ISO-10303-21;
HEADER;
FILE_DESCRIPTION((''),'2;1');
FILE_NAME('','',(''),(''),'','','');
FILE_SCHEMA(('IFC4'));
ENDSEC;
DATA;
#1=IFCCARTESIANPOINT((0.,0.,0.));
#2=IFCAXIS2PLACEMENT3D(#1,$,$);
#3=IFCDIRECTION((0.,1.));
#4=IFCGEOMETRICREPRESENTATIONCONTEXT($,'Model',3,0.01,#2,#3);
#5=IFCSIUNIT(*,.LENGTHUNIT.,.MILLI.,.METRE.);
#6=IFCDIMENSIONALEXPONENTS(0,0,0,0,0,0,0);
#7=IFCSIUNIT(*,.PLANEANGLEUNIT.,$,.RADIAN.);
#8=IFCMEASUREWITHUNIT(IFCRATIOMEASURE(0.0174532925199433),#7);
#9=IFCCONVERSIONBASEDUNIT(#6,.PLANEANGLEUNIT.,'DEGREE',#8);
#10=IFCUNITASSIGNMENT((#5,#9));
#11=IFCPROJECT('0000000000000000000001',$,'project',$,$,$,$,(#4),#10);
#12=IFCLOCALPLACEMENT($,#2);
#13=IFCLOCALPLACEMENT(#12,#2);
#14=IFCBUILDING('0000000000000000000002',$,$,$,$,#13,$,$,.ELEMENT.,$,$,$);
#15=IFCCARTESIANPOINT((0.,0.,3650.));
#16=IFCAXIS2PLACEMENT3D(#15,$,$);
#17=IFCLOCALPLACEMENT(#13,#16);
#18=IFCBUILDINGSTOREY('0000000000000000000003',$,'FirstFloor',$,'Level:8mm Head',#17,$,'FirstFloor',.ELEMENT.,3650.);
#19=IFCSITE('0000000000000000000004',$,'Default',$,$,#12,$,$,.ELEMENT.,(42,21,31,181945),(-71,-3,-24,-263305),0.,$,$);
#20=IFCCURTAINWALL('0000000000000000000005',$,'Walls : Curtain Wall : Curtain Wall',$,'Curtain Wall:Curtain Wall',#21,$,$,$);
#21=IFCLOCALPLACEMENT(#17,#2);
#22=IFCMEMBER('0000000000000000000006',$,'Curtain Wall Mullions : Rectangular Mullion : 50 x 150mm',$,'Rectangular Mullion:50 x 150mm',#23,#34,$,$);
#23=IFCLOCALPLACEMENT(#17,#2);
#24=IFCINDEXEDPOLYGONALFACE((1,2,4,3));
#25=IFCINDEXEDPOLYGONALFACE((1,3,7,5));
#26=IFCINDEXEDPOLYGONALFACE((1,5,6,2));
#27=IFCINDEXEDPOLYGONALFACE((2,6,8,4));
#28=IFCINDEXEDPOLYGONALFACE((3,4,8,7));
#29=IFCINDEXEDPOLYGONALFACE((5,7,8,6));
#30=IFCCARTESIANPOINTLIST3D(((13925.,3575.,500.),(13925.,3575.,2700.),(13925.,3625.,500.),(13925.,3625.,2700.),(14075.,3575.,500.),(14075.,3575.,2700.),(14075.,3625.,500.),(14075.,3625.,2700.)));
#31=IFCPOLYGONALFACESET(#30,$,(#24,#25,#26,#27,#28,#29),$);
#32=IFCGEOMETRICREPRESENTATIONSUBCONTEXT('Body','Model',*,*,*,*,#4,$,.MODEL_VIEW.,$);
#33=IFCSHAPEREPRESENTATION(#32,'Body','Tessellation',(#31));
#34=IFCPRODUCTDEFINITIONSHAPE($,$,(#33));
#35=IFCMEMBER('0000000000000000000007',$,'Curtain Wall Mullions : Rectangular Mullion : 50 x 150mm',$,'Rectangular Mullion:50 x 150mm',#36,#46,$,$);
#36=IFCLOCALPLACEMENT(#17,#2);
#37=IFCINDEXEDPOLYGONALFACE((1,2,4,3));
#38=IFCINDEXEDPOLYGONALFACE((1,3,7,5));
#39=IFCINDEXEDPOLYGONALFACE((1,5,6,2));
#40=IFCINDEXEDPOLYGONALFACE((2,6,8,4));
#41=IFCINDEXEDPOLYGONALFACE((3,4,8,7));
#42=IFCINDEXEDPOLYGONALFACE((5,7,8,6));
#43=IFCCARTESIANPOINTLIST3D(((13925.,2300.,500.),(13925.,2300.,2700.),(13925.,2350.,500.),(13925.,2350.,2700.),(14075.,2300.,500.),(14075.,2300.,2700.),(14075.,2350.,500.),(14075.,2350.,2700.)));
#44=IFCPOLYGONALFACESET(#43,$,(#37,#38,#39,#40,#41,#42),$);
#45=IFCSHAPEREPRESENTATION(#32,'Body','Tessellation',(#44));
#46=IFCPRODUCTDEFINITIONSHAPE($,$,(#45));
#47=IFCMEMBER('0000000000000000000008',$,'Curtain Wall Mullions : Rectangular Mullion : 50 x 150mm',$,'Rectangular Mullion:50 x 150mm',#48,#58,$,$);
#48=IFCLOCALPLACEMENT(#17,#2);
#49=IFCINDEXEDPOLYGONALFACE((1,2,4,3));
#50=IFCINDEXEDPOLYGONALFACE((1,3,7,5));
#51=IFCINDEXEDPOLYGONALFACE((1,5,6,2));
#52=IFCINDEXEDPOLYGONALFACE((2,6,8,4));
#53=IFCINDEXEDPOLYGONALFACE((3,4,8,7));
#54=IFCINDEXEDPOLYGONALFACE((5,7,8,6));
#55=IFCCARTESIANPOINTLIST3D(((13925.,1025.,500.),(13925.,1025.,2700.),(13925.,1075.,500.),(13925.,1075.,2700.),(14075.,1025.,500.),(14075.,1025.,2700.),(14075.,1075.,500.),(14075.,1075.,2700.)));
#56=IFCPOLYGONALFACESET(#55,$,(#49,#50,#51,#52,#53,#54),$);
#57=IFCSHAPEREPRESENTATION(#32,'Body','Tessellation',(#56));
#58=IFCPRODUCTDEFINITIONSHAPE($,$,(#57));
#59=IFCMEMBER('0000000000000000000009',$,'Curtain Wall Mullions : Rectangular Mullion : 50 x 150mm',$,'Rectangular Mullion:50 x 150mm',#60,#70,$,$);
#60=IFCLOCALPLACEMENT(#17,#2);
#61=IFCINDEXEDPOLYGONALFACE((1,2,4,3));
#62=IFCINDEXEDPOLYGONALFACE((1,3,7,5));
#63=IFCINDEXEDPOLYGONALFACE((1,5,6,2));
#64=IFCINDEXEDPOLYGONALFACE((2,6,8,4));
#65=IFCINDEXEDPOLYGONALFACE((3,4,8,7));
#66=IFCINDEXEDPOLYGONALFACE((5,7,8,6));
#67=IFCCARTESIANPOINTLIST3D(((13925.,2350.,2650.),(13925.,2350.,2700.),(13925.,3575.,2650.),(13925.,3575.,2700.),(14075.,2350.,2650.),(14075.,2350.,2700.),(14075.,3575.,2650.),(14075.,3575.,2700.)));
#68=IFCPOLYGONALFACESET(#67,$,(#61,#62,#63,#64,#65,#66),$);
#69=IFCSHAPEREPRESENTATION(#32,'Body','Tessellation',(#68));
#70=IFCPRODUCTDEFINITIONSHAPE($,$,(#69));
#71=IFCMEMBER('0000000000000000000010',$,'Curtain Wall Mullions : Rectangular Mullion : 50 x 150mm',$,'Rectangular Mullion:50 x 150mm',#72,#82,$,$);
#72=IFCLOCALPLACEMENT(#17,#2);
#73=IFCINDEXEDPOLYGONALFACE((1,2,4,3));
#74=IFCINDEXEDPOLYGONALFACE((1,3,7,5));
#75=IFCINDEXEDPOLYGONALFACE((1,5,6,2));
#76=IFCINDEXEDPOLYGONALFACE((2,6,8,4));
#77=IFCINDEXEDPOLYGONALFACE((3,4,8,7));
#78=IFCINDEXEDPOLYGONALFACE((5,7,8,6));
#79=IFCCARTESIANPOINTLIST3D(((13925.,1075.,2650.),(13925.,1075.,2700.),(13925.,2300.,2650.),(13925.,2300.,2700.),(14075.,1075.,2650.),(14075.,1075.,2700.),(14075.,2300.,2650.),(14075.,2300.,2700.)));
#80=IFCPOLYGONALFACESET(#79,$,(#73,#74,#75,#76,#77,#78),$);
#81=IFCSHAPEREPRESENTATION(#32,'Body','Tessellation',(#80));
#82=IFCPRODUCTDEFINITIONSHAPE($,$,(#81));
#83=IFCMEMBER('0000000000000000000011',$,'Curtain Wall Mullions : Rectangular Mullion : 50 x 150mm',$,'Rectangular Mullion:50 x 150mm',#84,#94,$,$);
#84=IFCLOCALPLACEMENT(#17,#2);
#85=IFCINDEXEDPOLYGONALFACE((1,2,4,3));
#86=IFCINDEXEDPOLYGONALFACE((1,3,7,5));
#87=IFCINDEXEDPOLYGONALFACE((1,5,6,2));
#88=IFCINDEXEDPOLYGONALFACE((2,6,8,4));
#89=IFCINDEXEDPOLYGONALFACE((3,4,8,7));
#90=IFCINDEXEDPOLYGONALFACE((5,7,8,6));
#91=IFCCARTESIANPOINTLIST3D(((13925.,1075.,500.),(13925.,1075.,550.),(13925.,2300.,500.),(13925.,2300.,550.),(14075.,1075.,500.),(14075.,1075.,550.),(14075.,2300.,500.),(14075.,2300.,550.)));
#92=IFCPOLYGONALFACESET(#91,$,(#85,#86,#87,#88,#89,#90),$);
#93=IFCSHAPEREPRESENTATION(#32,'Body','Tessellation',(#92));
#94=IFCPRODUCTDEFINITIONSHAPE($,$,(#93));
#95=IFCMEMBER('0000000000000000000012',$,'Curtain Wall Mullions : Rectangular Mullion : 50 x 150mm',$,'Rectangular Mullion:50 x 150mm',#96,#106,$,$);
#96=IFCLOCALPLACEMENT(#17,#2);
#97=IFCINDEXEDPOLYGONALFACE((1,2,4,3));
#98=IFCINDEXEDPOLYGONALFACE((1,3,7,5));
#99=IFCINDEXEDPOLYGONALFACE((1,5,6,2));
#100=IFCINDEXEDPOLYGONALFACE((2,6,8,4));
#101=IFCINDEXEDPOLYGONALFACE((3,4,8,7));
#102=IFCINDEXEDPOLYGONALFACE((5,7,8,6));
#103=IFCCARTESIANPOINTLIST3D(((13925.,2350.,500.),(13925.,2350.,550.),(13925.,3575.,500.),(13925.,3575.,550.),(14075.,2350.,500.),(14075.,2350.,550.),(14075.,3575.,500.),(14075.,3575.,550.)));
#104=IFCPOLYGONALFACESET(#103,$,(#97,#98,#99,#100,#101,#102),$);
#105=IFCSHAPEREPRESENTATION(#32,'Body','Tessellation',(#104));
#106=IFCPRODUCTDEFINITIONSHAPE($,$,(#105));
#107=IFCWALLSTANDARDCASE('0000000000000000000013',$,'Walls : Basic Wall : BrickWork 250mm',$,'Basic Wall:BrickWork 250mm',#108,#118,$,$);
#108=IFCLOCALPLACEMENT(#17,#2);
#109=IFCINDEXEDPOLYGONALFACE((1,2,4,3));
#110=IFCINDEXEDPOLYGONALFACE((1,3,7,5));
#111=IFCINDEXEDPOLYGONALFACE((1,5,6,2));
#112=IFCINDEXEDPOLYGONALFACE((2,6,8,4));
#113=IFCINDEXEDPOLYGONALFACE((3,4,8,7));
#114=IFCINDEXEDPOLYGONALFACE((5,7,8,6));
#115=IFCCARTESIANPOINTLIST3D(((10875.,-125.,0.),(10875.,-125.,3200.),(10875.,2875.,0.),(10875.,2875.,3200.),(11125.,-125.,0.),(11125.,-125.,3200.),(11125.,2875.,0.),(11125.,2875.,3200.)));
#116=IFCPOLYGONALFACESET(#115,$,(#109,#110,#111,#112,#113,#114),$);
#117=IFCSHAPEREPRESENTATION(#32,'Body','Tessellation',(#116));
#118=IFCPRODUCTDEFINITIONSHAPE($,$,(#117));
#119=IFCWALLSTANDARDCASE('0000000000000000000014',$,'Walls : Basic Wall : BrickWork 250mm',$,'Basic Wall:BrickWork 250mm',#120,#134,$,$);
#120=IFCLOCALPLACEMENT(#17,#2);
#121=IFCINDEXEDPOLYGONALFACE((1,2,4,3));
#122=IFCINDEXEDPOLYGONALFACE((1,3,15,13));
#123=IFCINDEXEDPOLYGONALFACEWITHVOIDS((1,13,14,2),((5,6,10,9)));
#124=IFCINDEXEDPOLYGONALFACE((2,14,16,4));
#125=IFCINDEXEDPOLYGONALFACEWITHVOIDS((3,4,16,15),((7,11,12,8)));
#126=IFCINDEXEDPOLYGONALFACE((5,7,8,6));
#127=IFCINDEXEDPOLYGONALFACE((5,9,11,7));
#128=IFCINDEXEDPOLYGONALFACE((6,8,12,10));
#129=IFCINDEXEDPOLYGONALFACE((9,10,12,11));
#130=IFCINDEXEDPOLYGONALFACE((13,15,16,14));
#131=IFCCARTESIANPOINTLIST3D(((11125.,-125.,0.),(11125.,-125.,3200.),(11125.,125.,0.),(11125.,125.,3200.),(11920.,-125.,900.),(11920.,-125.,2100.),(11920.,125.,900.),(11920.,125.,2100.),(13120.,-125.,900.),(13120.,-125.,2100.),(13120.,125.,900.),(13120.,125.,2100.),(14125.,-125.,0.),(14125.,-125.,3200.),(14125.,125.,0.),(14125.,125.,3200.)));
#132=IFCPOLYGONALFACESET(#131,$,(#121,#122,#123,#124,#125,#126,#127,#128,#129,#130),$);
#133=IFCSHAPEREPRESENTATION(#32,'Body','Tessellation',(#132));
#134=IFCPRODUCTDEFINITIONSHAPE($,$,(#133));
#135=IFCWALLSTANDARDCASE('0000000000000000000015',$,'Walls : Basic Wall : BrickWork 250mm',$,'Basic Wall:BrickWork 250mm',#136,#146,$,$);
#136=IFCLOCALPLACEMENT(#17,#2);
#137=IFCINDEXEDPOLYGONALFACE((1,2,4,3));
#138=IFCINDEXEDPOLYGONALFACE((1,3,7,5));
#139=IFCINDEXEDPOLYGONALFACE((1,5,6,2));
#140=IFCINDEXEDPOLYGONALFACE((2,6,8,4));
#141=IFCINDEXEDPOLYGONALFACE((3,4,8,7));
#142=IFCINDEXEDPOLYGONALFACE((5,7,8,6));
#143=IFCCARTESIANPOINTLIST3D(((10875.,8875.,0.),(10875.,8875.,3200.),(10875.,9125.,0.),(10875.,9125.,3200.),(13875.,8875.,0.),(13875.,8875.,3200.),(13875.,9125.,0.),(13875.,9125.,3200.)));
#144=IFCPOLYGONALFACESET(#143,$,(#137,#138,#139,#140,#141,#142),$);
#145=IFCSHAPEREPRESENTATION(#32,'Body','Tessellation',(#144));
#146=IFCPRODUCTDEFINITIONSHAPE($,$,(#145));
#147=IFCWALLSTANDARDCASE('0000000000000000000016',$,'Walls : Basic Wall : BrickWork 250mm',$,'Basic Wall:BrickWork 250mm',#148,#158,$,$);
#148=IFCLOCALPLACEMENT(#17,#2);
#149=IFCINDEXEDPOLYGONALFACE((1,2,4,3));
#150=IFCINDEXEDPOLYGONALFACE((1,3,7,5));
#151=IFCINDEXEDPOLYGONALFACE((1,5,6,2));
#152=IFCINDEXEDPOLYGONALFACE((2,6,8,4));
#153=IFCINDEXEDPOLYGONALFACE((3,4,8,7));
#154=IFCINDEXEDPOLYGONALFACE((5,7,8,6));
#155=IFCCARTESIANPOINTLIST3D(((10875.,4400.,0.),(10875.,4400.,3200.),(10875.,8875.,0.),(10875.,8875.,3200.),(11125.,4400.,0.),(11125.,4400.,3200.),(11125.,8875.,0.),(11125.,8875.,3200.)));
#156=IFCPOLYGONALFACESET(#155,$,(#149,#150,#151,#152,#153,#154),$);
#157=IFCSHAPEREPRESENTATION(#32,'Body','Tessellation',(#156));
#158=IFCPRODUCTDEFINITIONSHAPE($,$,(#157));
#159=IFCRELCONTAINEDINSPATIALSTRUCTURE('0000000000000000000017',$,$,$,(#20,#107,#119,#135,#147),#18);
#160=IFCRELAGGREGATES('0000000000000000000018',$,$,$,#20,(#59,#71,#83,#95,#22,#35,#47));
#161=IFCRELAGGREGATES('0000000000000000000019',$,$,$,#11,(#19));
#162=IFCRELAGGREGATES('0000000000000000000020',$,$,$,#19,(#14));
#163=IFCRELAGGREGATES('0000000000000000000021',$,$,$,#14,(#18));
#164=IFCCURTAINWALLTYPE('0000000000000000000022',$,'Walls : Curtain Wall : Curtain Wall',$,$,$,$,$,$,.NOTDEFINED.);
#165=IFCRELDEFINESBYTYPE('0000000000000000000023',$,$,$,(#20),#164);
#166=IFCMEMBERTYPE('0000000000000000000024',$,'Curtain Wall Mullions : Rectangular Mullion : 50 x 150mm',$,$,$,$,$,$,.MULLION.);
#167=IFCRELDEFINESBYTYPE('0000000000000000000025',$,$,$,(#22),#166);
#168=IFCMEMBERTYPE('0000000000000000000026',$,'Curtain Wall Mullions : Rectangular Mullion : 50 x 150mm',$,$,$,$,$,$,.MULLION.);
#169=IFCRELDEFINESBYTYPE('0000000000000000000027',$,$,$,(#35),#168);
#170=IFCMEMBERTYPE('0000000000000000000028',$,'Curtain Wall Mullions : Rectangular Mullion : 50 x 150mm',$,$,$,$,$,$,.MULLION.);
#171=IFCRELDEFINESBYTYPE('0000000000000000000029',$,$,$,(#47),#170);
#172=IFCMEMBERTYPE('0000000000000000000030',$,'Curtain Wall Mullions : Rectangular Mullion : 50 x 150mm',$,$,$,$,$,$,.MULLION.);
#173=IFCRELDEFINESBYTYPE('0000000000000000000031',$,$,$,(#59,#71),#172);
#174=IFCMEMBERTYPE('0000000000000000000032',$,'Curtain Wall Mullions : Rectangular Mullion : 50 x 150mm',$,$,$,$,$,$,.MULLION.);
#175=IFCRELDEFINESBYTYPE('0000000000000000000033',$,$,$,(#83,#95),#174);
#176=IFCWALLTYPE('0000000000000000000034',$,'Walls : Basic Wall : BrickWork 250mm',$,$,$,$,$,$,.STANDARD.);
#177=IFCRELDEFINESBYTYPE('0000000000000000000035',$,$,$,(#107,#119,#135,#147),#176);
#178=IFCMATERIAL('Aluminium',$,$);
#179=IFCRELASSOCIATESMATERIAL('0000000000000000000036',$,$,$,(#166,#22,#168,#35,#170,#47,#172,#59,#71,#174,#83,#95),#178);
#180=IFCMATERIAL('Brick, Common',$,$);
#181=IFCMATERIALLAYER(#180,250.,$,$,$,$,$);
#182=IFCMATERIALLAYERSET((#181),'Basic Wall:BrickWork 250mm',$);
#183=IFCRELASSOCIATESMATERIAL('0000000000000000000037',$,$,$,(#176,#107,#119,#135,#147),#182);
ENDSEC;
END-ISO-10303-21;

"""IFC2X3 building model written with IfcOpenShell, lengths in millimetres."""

from ifc_helpers import new_model, entity, si_unit, converted_unit, direction, frame, frame_2d, origin, origin_2d_with_axis, place, context, subcontext, project, spatial, rectangle, extrude, clip, halfspace, source, transform, mapped, material, layer, layer_set, layer_usage, type_object, type_shapes, element, aggregate, save


model = new_model("IFC2X3")

# Units and contexts
model_context = context("Model", 3, precision=0.01, world=origin(), true_north=direction((0.0, 1.0)))
body_context = subcontext(model_context, "Body", "Model", "MODEL_VIEW")
ifc_project = project(units=[si_unit("LENGTHUNIT", "METRE", prefix="MILLI"), converted_unit("PLANEANGLEUNIT", "DEGREE", entity("IfcRatioMeasure", 0.0174532925199433), si_unit("PLANEANGLEUNIT", "RADIAN"), dimensions=[0, 0, 0, 0, 0, 0, 0])], contexts=[model_context])

# Site, building, storey
site_placement = place(None, origin())
site = spatial("IfcSite", under=ifc_project, at=site_placement, Name="Default", CompositionType="ELEMENT", RefLatitude=(42, 21, 31, 181945), RefLongitude=(-71, -3, -24, -263305), RefElevation=0.0)
building_placement = place(site_placement, origin())
building = spatial("IfcBuilding", under=site, at=building_placement, CompositionType="ELEMENT")
storey_placement = place(building_placement, frame((0.0, 0.0, 3650.0)))
storey = spatial("IfcBuildingStorey", under=building, at=storey_placement, Name="FirstFloor", ObjectType="Level:8mm Head", LongName="FirstFloor", CompositionType="ELEMENT", Elevation=3650.0)

# Curtain wall, members
curtain_wall_type = type_object("IfcCurtainWallType", Name="Walls : Curtain Wall : Curtain Wall", PredefinedType="NOTDEFINED")
curtain_wall_placement = place(storey_placement, frame((0.0, 0.0, -3650.0)))
curtain_wall = element("IfcCurtainWall", 1, at=curtain_wall_placement, inside=storey, type_object=curtain_wall_type, Name="Walls : Curtain Wall : Curtain Wall", ObjectType="Curtain Wall:Curtain Wall")
ifc_material_1 = material(Name="Aluminium")
member_type_1 = type_object("IfcMemberType", Name="Curtain Wall Mullions : Rectangular Mullion : 50 x 150mm", PredefinedType="MULLION", material=ifc_material_1)
shared_shape_1 = source(origin(), body_context, "Body", "SweptSolid", [
    extrude(rectangle(XDim=150.0, YDim=50.0, at=origin_2d_with_axis()), frame((-25.0, 0.0, -2200.0), z_axis=(0.0, 0.0, 1.0), x_axis=(0.0, -1.0, 0.0)), (0.0, 0.0, 1.0), 2200.0),
])
type_shapes(member_type_1, [shared_shape_1])
member_1_placement = place(storey_placement, frame((14000.0, 3625.0, 500.0), z_axis=(0.0, 0.0, -1.0), x_axis=(0.0, 1.0, 0.0)))
member_1 = element("IfcMember", 2, at=member_1_placement, type_object=member_type_1, material=ifc_material_1, Name="Curtain Wall Mullions : Rectangular Mullion : 50 x 150mm", ObjectType="Rectangular Mullion:50 x 150mm", context=body_context, shape_type="MappedRepresentation", body=[
    mapped(shared_shape_1, transform((0.0, 0.0, 0.0), scale=1.0)),
])
member_type_2 = type_object("IfcMemberType", Name="Curtain Wall Mullions : Rectangular Mullion : 50 x 150mm", PredefinedType="MULLION", material=ifc_material_1)
shared_shape_2 = source(origin(), body_context, "Body", "SweptSolid", [
    extrude(rectangle(XDim=150.0, YDim=50.0, at=origin_2d_with_axis()), frame((0.0, 0.0, -2200.0), z_axis=(0.0, 0.0, 1.0), x_axis=(0.0, -1.0, 0.0)), (0.0, 0.0, 1.0), 2200.0),
])
type_shapes(member_type_2, [shared_shape_2])
member_2_placement = place(storey_placement, frame((14000.0, 2325.0, 500.0), z_axis=(0.0, 0.0, -1.0), x_axis=(0.0, 1.0, 0.0)))
member_2 = element("IfcMember", 3, at=member_2_placement, type_object=member_type_2, material=ifc_material_1, Name="Curtain Wall Mullions : Rectangular Mullion : 50 x 150mm", ObjectType="Rectangular Mullion:50 x 150mm", context=body_context, shape_type="MappedRepresentation", body=[
    mapped(shared_shape_2, transform((0.0, 0.0, 0.0), scale=1.0)),
])
member_type_3 = type_object("IfcMemberType", Name="Curtain Wall Mullions : Rectangular Mullion : 50 x 150mm", PredefinedType="MULLION", material=ifc_material_1)
shared_shape_3 = source(origin(), body_context, "Body", "SweptSolid", [
    extrude(rectangle(XDim=150.0, YDim=50.0, at=origin_2d_with_axis()), frame((-25.0, 0.0, -2200.0), z_axis=(0.0, 0.0, 1.0), x_axis=(0.0, -1.0, 0.0)), (0.0, 0.0, 1.0), 2200.0),
])
type_shapes(member_type_3, [shared_shape_3])
member_3_placement = place(storey_placement, frame((14000.0, 1025.0, 2700.0), z_axis=(0.0, 0.0, 1.0), x_axis=(0.0, -1.0, 0.0)))
member_3 = element("IfcMember", 4, at=member_3_placement, type_object=member_type_3, material=ifc_material_1, Name="Curtain Wall Mullions : Rectangular Mullion : 50 x 150mm", ObjectType="Rectangular Mullion:50 x 150mm", context=body_context, shape_type="MappedRepresentation", body=[
    mapped(shared_shape_3, transform((0.0, 0.0, 0.0), scale=1.0)),
])
member_type_4 = type_object("IfcMemberType", Name="Curtain Wall Mullions : Rectangular Mullion : 50 x 150mm", PredefinedType="MULLION", material=ifc_material_1)
shared_shape_4 = source(origin(), body_context, "Body", "SweptSolid", [
    extrude(rectangle(XDim=150.0, YDim=50.0, at=origin_2d_with_axis()), frame((-25.0, 0.0, -1225.0), z_axis=(0.0, 0.0, 1.0), x_axis=(0.0, -1.0, 0.0)), (0.0, 0.0, 1.0), 1225.0),
])
type_shapes(member_type_4, [shared_shape_4])
member_4_placement = place(storey_placement, frame((14000.0, 3575.0, 2700.0), z_axis=(0.0, 1.0, 0.0), x_axis=(0.0, 0.0, 1.0)))
member_4 = element("IfcMember", 5, at=member_4_placement, type_object=member_type_4, material=ifc_material_1, Name="Curtain Wall Mullions : Rectangular Mullion : 50 x 150mm", ObjectType="Rectangular Mullion:50 x 150mm", context=body_context, shape_type="MappedRepresentation", body=[
    mapped(shared_shape_4, transform((0.0, 0.0, 0.0), scale=1.0)),
])
member_5_placement = place(storey_placement, frame((14000.0, 2300.0, 2700.0), z_axis=(0.0, 1.0, 0.0), x_axis=(0.0, 0.0, 1.0)))
member_5 = element("IfcMember", 6, at=member_5_placement, type_object=member_type_4, material=ifc_material_1, Name="Curtain Wall Mullions : Rectangular Mullion : 50 x 150mm", ObjectType="Rectangular Mullion:50 x 150mm", context=body_context, shape_type="MappedRepresentation", body=[
    mapped(shared_shape_4, transform((0.0, 0.0, 0.0), scale=1.0)),
])
member_type_5 = type_object("IfcMemberType", Name="Curtain Wall Mullions : Rectangular Mullion : 50 x 150mm", PredefinedType="MULLION", material=ifc_material_1)
shared_shape_5 = source(origin(), body_context, "Body", "SweptSolid", [
    extrude(rectangle(XDim=150.0, YDim=50.0, at=origin_2d_with_axis()), frame((-25.0, 0.0, -1225.0), z_axis=(0.0, 0.0, 1.0), x_axis=(0.0, -1.0, 0.0)), (0.0, 0.0, 1.0), 1225.0),
])
type_shapes(member_type_5, [shared_shape_5])
member_6_placement = place(storey_placement, frame((14000.0, 1075.0, 500.0), z_axis=(0.0, -1.0, 0.0), x_axis=(0.0, 0.0, -1.0)))
member_6 = element("IfcMember", 7, at=member_6_placement, type_object=member_type_5, material=ifc_material_1, Name="Curtain Wall Mullions : Rectangular Mullion : 50 x 150mm", ObjectType="Rectangular Mullion:50 x 150mm", context=body_context, shape_type="MappedRepresentation", body=[
    mapped(shared_shape_5, transform((0.0, 0.0, 0.0), scale=1.0)),
])
member_7_placement = place(storey_placement, frame((14000.0, 2350.0, 500.0), z_axis=(0.0, -1.0, 0.0), x_axis=(0.0, 0.0, -1.0)))
member_7 = element("IfcMember", 8, at=member_7_placement, type_object=member_type_5, material=ifc_material_1, Name="Curtain Wall Mullions : Rectangular Mullion : 50 x 150mm", ObjectType="Rectangular Mullion:50 x 150mm", context=body_context, shape_type="MappedRepresentation", body=[
    mapped(shared_shape_5, transform((0.0, 0.0, 0.0), scale=1.0)),
])
aggregate(curtain_wall, [member_4, member_5, member_6, member_7, member_1, member_2, member_3])

# Wall
ifc_material_2 = material(Name="Brick, Common")
ifc_layer = layer(ifc_material_2, 250.0)
ifc_layer_set = layer_set([ifc_layer], Name="Basic Wall:BrickWork 250mm")
ifc_layer_usage_1 = layer_usage(ifc_layer_set, "AXIS2", "POSITIVE", -125.0)
wall_type = type_object("IfcWallType", Name="Walls : Basic Wall : BrickWork 250mm", PredefinedType="STANDARD", material=ifc_layer_set)
wall_1_placement = place(storey_placement, frame((11000.0, 2875.0, 0.0), z_axis=(0.0, 0.0, 1.0), x_axis=(0.0, -1.0, 0.0)))
element("IfcWallStandardCase", 9, at=wall_1_placement, inside=storey, type_object=wall_type, material=ifc_layer_usage_1, Name="Walls : Basic Wall : BrickWork 250mm", ObjectType="Basic Wall:BrickWork 250mm", context=body_context, shape_type="Clipping", body=[
    clip(extrude(rectangle(XDim=3000.0, YDim=250.0, at=frame_2d((1500.0, 0.0), x_axis=(-1.0, 0.0))), origin(), (0.0, 0.0, 1.0), 3200.0), halfspace(frame((0.0, 0.0, -3200.0)), True)),
])

# Wall, opening
ifc_layer_usage_2 = layer_usage(ifc_layer_set, "AXIS2", "POSITIVE", -125.0)
wall_2_placement = place(storey_placement, frame((11125.0, 0.0, 0.0)))
wall_2 = element("IfcWallStandardCase", 10, at=wall_2_placement, inside=storey, type_object=wall_type, material=ifc_layer_usage_2, Name="Walls : Basic Wall : BrickWork 250mm", ObjectType="Basic Wall:BrickWork 250mm", context=body_context, shape_type="Clipping", body=[
    clip(extrude(rectangle(XDim=3000.0, YDim=250.0, at=frame_2d((1500.0, 0.0), x_axis=(-1.0, 0.0))), origin(), (0.0, 0.0, 1.0), 3200.0), halfspace(frame((0.0, 0.0, -3200.0)), True)),
])
opening_1_placement = place(wall_2_placement, frame((1995.0, 125.0, 900.0)))
element("IfcOpeningElement", 11, at=opening_1_placement, cuts=wall_2, ObjectType="Opening", context=body_context, shape_type="SweptSolid", body=[
    extrude(rectangle(XDim=1200.0, YDim=1200.0, at=frame_2d((600.0, 600.0), x_axis=(-1.0, 0.0))), frame((0.0, 0.0, 0.0), z_axis=(0.0, -1.0, 0.0), x_axis=(0.0, 0.0, 1.0)), (0.0, 0.0, 1.0), 250.0),
])

# Walls
ifc_layer_usage_3 = layer_usage(ifc_layer_set, "AXIS2", "POSITIVE", -125.0)
wall_3_placement = place(storey_placement, frame((13875.0, 9000.0, 0.0), z_axis=(0.0, 0.0, 1.0), x_axis=(-1.0, 0.0, 0.0)))
element("IfcWallStandardCase", 12, at=wall_3_placement, inside=storey, type_object=wall_type, material=ifc_layer_usage_3, Name="Walls : Basic Wall : BrickWork 250mm", ObjectType="Basic Wall:BrickWork 250mm", context=body_context, shape_type="Clipping", body=[
    clip(extrude(rectangle(XDim=3000.0, YDim=250.0, at=frame_2d((1500.0, 0.0), x_axis=(-1.0, 0.0))), origin(), (0.0, 0.0, 1.0), 3200.0), halfspace(frame((0.0, 0.0, -3200.0)), True)),
])
ifc_layer_usage_4 = layer_usage(ifc_layer_set, "AXIS2", "POSITIVE", -125.0)
wall_4_placement = place(storey_placement, frame((11000.0, 8875.0, 0.0), z_axis=(0.0, 0.0, 1.0), x_axis=(0.0, -1.0, 0.0)))
element("IfcWallStandardCase", 13, at=wall_4_placement, inside=storey, type_object=wall_type, material=ifc_layer_usage_4, Name="Walls : Basic Wall : BrickWork 250mm", ObjectType="Basic Wall:BrickWork 250mm", context=body_context, shape_type="SweptSolid", body=[
    extrude(rectangle(XDim=4475.0, YDim=250.0, at=frame_2d((2237.5, 0.0), x_axis=(-1.0, 0.0))), origin(), (0.0, 0.0, 1.0), 3200.0),
])

save(model, "model.ifc")
